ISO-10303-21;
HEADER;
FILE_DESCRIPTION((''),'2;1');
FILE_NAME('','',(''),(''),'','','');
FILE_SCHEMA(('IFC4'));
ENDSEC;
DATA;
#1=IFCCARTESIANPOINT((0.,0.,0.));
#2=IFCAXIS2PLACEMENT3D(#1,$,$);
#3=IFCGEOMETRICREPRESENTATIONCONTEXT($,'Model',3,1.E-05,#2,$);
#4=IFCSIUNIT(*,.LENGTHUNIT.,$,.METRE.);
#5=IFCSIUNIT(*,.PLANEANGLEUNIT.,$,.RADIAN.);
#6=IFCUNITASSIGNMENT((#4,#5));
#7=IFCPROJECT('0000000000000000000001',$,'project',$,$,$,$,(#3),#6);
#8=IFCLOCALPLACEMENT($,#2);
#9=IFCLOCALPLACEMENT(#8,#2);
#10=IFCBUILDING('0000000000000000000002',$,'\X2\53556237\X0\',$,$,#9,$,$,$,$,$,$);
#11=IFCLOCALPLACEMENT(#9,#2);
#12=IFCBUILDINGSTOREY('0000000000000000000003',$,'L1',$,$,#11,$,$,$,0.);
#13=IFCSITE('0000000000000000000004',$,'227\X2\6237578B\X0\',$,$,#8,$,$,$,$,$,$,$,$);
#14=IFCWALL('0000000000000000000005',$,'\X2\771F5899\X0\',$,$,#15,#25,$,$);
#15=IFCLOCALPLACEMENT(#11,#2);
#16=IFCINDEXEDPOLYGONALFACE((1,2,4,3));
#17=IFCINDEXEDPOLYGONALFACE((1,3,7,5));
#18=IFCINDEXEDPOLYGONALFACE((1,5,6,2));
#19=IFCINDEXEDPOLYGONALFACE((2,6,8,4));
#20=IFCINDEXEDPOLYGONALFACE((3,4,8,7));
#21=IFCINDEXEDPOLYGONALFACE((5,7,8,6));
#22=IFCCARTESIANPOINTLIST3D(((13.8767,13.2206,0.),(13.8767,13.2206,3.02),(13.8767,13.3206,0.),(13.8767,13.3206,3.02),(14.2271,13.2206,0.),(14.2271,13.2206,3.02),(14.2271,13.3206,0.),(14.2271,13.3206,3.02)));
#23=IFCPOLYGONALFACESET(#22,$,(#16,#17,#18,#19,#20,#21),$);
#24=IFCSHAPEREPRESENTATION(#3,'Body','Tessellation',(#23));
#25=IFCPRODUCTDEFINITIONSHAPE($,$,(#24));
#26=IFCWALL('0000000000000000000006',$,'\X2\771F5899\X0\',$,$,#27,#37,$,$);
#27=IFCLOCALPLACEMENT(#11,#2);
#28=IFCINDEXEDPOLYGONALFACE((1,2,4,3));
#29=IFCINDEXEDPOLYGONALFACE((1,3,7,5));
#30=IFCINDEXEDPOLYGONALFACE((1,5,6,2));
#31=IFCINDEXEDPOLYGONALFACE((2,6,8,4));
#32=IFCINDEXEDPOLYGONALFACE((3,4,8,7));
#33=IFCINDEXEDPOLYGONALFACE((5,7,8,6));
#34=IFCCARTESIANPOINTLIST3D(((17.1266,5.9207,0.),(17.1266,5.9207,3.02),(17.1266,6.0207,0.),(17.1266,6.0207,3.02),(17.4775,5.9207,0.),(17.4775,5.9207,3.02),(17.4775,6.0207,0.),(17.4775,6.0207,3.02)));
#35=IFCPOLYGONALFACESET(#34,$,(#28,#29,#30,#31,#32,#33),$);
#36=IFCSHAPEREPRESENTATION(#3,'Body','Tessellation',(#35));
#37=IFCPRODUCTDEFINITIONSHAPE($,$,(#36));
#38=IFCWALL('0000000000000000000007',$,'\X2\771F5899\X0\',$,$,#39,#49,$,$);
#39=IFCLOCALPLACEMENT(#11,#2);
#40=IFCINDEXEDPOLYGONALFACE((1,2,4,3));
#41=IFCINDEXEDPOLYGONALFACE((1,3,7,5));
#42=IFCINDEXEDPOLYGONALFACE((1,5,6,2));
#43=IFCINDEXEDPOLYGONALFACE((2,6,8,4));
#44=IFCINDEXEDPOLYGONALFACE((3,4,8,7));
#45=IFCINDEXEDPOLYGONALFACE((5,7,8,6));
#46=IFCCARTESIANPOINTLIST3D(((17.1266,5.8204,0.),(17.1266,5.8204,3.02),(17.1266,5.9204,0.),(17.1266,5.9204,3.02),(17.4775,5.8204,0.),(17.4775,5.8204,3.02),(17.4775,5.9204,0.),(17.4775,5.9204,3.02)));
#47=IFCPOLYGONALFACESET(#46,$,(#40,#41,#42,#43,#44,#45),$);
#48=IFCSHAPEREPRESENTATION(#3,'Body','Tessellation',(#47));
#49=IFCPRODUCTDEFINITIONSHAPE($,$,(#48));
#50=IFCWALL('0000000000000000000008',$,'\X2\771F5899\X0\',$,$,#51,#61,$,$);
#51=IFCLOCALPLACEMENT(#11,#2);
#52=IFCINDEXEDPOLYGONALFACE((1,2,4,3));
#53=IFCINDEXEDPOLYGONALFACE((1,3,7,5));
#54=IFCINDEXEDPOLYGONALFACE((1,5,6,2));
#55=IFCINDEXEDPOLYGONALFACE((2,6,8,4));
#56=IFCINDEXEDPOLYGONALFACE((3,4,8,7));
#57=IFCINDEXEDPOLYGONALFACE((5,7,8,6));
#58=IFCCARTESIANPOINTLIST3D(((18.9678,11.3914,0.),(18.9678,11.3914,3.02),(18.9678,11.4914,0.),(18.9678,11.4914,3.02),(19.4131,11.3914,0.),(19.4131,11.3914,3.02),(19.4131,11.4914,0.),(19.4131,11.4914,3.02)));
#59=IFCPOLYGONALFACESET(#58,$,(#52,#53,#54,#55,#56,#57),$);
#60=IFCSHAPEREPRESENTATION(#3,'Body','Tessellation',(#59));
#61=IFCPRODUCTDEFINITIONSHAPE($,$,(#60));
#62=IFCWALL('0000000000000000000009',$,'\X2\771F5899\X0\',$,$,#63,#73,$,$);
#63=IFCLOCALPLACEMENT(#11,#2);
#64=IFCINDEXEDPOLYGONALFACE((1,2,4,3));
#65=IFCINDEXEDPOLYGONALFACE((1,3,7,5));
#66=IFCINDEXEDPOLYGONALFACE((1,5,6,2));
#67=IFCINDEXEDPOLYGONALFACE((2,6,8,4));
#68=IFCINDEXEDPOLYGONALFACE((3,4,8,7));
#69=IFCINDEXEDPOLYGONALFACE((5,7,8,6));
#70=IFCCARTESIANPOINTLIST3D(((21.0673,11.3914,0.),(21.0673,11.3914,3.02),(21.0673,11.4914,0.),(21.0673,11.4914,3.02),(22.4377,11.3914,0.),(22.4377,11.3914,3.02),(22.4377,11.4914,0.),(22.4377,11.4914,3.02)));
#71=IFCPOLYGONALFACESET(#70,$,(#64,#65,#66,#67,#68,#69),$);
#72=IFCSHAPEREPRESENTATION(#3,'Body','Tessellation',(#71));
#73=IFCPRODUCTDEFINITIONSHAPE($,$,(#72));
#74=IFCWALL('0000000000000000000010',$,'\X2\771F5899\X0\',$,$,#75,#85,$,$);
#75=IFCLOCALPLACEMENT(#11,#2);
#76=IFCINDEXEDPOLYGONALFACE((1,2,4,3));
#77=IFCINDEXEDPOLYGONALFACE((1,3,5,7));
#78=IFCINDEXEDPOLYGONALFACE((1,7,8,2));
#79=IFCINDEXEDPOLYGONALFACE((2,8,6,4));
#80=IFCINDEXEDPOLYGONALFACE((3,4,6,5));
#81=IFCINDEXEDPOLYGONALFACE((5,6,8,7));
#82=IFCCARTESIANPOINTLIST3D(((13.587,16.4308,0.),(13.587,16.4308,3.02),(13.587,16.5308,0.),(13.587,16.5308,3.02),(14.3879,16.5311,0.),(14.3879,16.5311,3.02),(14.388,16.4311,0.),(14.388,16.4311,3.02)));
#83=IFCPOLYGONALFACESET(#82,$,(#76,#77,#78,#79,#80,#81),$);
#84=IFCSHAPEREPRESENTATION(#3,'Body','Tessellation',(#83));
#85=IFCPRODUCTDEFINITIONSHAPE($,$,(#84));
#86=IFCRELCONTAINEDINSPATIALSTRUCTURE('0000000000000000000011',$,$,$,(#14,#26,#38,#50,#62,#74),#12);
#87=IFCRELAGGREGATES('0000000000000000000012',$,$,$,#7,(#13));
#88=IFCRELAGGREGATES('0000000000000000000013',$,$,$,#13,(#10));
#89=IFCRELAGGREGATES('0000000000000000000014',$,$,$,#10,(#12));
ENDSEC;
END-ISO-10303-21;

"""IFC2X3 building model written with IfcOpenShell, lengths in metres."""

from ifc_helpers import new_model, si_unit, origin, place, context, project, spatial, polyline, outline, extrude, element, save


model = new_model("IFC2X3")

# Units and contexts
model_context = context("Model", 3, precision=1e-05, world=origin())
ifc_project = project(units=[si_unit("LENGTHUNIT", "METRE"), si_unit("PLANEANGLEUNIT", "RADIAN")], contexts=[model_context])

# Site, building, storey
site_placement = place(None, origin())
site = spatial("IfcSite", under=ifc_project, at=site_placement, Name="227户型")
building_placement = place(site_placement, origin())
building = spatial("IfcBuilding", under=site, at=building_placement, Name="单户")
storey_placement = place(building_placement, origin())
storey = spatial("IfcBuildingStorey", under=building, at=storey_placement, Name="L1", Elevation=0.0)

# Walls
wall_1_placement = place(storey_placement, origin())
element("IfcWall", 1, at=wall_1_placement, inside=storey, Name="真墙", context=model_context, shape_type="SweptSolid", body=[
    extrude(outline(polyline([(13.8767, 13.3206), (14.2271, 13.3206), (14.2271, 13.2206), (13.8767, 13.2206), (13.8767, 13.3206)])), origin(), (0.0, 0.0, 1.0), 3.02),
])
wall_2_placement = place(storey_placement, origin())
element("IfcWall", 2, at=wall_2_placement, inside=storey, Name="真墙", context=model_context, shape_type="SweptSolid", body=[
    extrude(outline(polyline([(17.4775, 5.9207), (17.1266, 5.9207), (17.1266, 6.0207), (17.4775, 6.0207), (17.4775, 5.9207)])), origin(), (0.0, 0.0, 1.0), 3.02),
])
wall_3_placement = place(storey_placement, origin())
element("IfcWall", 3, at=wall_3_placement, inside=storey, Name="真墙", context=model_context, shape_type="SweptSolid", body=[
    extrude(outline(polyline([(17.1266, 5.9204), (17.4775, 5.9204), (17.4775, 5.8204), (17.1266, 5.8204), (17.1266, 5.9204)])), origin(), (0.0, 0.0, 1.0), 3.02),
])
wall_4_placement = place(storey_placement, origin())
element("IfcWall", 4, at=wall_4_placement, inside=storey, Name="真墙", context=model_context, shape_type="SweptSolid", body=[
    extrude(outline(polyline([(19.4131, 11.3914), (18.9678, 11.3914), (18.9678, 11.4914), (19.4131, 11.4914), (19.4131, 11.3914)])), origin(), (0.0, 0.0, 1.0), 3.02),
])

# Walls
wall_5_placement = place(storey_placement, origin())
element("IfcWall", 5, at=wall_5_placement, inside=storey, Name="真墙", context=model_context, shape_type="SweptSolid", body=[
    extrude(outline(polyline([(21.0673, 11.4914), (22.4377, 11.4914), (22.4377, 11.3914), (21.0673, 11.3914), (21.0673, 11.4914)])), origin(), (0.0, 0.0, 1.0), 3.02),
])
wall_6_placement = place(storey_placement, origin())
element("IfcWall", 6, at=wall_6_placement, inside=storey, Name="真墙", context=model_context, shape_type="SweptSolid", body=[
    extrude(outline(polyline([(13.587, 16.5308), (14.3879, 16.5311), (14.388, 16.4311), (13.587, 16.4308), (13.587, 16.5308)])), origin(), (0.0, 0.0, 1.0), 3.02),
])

save(model, "model.ifc")
